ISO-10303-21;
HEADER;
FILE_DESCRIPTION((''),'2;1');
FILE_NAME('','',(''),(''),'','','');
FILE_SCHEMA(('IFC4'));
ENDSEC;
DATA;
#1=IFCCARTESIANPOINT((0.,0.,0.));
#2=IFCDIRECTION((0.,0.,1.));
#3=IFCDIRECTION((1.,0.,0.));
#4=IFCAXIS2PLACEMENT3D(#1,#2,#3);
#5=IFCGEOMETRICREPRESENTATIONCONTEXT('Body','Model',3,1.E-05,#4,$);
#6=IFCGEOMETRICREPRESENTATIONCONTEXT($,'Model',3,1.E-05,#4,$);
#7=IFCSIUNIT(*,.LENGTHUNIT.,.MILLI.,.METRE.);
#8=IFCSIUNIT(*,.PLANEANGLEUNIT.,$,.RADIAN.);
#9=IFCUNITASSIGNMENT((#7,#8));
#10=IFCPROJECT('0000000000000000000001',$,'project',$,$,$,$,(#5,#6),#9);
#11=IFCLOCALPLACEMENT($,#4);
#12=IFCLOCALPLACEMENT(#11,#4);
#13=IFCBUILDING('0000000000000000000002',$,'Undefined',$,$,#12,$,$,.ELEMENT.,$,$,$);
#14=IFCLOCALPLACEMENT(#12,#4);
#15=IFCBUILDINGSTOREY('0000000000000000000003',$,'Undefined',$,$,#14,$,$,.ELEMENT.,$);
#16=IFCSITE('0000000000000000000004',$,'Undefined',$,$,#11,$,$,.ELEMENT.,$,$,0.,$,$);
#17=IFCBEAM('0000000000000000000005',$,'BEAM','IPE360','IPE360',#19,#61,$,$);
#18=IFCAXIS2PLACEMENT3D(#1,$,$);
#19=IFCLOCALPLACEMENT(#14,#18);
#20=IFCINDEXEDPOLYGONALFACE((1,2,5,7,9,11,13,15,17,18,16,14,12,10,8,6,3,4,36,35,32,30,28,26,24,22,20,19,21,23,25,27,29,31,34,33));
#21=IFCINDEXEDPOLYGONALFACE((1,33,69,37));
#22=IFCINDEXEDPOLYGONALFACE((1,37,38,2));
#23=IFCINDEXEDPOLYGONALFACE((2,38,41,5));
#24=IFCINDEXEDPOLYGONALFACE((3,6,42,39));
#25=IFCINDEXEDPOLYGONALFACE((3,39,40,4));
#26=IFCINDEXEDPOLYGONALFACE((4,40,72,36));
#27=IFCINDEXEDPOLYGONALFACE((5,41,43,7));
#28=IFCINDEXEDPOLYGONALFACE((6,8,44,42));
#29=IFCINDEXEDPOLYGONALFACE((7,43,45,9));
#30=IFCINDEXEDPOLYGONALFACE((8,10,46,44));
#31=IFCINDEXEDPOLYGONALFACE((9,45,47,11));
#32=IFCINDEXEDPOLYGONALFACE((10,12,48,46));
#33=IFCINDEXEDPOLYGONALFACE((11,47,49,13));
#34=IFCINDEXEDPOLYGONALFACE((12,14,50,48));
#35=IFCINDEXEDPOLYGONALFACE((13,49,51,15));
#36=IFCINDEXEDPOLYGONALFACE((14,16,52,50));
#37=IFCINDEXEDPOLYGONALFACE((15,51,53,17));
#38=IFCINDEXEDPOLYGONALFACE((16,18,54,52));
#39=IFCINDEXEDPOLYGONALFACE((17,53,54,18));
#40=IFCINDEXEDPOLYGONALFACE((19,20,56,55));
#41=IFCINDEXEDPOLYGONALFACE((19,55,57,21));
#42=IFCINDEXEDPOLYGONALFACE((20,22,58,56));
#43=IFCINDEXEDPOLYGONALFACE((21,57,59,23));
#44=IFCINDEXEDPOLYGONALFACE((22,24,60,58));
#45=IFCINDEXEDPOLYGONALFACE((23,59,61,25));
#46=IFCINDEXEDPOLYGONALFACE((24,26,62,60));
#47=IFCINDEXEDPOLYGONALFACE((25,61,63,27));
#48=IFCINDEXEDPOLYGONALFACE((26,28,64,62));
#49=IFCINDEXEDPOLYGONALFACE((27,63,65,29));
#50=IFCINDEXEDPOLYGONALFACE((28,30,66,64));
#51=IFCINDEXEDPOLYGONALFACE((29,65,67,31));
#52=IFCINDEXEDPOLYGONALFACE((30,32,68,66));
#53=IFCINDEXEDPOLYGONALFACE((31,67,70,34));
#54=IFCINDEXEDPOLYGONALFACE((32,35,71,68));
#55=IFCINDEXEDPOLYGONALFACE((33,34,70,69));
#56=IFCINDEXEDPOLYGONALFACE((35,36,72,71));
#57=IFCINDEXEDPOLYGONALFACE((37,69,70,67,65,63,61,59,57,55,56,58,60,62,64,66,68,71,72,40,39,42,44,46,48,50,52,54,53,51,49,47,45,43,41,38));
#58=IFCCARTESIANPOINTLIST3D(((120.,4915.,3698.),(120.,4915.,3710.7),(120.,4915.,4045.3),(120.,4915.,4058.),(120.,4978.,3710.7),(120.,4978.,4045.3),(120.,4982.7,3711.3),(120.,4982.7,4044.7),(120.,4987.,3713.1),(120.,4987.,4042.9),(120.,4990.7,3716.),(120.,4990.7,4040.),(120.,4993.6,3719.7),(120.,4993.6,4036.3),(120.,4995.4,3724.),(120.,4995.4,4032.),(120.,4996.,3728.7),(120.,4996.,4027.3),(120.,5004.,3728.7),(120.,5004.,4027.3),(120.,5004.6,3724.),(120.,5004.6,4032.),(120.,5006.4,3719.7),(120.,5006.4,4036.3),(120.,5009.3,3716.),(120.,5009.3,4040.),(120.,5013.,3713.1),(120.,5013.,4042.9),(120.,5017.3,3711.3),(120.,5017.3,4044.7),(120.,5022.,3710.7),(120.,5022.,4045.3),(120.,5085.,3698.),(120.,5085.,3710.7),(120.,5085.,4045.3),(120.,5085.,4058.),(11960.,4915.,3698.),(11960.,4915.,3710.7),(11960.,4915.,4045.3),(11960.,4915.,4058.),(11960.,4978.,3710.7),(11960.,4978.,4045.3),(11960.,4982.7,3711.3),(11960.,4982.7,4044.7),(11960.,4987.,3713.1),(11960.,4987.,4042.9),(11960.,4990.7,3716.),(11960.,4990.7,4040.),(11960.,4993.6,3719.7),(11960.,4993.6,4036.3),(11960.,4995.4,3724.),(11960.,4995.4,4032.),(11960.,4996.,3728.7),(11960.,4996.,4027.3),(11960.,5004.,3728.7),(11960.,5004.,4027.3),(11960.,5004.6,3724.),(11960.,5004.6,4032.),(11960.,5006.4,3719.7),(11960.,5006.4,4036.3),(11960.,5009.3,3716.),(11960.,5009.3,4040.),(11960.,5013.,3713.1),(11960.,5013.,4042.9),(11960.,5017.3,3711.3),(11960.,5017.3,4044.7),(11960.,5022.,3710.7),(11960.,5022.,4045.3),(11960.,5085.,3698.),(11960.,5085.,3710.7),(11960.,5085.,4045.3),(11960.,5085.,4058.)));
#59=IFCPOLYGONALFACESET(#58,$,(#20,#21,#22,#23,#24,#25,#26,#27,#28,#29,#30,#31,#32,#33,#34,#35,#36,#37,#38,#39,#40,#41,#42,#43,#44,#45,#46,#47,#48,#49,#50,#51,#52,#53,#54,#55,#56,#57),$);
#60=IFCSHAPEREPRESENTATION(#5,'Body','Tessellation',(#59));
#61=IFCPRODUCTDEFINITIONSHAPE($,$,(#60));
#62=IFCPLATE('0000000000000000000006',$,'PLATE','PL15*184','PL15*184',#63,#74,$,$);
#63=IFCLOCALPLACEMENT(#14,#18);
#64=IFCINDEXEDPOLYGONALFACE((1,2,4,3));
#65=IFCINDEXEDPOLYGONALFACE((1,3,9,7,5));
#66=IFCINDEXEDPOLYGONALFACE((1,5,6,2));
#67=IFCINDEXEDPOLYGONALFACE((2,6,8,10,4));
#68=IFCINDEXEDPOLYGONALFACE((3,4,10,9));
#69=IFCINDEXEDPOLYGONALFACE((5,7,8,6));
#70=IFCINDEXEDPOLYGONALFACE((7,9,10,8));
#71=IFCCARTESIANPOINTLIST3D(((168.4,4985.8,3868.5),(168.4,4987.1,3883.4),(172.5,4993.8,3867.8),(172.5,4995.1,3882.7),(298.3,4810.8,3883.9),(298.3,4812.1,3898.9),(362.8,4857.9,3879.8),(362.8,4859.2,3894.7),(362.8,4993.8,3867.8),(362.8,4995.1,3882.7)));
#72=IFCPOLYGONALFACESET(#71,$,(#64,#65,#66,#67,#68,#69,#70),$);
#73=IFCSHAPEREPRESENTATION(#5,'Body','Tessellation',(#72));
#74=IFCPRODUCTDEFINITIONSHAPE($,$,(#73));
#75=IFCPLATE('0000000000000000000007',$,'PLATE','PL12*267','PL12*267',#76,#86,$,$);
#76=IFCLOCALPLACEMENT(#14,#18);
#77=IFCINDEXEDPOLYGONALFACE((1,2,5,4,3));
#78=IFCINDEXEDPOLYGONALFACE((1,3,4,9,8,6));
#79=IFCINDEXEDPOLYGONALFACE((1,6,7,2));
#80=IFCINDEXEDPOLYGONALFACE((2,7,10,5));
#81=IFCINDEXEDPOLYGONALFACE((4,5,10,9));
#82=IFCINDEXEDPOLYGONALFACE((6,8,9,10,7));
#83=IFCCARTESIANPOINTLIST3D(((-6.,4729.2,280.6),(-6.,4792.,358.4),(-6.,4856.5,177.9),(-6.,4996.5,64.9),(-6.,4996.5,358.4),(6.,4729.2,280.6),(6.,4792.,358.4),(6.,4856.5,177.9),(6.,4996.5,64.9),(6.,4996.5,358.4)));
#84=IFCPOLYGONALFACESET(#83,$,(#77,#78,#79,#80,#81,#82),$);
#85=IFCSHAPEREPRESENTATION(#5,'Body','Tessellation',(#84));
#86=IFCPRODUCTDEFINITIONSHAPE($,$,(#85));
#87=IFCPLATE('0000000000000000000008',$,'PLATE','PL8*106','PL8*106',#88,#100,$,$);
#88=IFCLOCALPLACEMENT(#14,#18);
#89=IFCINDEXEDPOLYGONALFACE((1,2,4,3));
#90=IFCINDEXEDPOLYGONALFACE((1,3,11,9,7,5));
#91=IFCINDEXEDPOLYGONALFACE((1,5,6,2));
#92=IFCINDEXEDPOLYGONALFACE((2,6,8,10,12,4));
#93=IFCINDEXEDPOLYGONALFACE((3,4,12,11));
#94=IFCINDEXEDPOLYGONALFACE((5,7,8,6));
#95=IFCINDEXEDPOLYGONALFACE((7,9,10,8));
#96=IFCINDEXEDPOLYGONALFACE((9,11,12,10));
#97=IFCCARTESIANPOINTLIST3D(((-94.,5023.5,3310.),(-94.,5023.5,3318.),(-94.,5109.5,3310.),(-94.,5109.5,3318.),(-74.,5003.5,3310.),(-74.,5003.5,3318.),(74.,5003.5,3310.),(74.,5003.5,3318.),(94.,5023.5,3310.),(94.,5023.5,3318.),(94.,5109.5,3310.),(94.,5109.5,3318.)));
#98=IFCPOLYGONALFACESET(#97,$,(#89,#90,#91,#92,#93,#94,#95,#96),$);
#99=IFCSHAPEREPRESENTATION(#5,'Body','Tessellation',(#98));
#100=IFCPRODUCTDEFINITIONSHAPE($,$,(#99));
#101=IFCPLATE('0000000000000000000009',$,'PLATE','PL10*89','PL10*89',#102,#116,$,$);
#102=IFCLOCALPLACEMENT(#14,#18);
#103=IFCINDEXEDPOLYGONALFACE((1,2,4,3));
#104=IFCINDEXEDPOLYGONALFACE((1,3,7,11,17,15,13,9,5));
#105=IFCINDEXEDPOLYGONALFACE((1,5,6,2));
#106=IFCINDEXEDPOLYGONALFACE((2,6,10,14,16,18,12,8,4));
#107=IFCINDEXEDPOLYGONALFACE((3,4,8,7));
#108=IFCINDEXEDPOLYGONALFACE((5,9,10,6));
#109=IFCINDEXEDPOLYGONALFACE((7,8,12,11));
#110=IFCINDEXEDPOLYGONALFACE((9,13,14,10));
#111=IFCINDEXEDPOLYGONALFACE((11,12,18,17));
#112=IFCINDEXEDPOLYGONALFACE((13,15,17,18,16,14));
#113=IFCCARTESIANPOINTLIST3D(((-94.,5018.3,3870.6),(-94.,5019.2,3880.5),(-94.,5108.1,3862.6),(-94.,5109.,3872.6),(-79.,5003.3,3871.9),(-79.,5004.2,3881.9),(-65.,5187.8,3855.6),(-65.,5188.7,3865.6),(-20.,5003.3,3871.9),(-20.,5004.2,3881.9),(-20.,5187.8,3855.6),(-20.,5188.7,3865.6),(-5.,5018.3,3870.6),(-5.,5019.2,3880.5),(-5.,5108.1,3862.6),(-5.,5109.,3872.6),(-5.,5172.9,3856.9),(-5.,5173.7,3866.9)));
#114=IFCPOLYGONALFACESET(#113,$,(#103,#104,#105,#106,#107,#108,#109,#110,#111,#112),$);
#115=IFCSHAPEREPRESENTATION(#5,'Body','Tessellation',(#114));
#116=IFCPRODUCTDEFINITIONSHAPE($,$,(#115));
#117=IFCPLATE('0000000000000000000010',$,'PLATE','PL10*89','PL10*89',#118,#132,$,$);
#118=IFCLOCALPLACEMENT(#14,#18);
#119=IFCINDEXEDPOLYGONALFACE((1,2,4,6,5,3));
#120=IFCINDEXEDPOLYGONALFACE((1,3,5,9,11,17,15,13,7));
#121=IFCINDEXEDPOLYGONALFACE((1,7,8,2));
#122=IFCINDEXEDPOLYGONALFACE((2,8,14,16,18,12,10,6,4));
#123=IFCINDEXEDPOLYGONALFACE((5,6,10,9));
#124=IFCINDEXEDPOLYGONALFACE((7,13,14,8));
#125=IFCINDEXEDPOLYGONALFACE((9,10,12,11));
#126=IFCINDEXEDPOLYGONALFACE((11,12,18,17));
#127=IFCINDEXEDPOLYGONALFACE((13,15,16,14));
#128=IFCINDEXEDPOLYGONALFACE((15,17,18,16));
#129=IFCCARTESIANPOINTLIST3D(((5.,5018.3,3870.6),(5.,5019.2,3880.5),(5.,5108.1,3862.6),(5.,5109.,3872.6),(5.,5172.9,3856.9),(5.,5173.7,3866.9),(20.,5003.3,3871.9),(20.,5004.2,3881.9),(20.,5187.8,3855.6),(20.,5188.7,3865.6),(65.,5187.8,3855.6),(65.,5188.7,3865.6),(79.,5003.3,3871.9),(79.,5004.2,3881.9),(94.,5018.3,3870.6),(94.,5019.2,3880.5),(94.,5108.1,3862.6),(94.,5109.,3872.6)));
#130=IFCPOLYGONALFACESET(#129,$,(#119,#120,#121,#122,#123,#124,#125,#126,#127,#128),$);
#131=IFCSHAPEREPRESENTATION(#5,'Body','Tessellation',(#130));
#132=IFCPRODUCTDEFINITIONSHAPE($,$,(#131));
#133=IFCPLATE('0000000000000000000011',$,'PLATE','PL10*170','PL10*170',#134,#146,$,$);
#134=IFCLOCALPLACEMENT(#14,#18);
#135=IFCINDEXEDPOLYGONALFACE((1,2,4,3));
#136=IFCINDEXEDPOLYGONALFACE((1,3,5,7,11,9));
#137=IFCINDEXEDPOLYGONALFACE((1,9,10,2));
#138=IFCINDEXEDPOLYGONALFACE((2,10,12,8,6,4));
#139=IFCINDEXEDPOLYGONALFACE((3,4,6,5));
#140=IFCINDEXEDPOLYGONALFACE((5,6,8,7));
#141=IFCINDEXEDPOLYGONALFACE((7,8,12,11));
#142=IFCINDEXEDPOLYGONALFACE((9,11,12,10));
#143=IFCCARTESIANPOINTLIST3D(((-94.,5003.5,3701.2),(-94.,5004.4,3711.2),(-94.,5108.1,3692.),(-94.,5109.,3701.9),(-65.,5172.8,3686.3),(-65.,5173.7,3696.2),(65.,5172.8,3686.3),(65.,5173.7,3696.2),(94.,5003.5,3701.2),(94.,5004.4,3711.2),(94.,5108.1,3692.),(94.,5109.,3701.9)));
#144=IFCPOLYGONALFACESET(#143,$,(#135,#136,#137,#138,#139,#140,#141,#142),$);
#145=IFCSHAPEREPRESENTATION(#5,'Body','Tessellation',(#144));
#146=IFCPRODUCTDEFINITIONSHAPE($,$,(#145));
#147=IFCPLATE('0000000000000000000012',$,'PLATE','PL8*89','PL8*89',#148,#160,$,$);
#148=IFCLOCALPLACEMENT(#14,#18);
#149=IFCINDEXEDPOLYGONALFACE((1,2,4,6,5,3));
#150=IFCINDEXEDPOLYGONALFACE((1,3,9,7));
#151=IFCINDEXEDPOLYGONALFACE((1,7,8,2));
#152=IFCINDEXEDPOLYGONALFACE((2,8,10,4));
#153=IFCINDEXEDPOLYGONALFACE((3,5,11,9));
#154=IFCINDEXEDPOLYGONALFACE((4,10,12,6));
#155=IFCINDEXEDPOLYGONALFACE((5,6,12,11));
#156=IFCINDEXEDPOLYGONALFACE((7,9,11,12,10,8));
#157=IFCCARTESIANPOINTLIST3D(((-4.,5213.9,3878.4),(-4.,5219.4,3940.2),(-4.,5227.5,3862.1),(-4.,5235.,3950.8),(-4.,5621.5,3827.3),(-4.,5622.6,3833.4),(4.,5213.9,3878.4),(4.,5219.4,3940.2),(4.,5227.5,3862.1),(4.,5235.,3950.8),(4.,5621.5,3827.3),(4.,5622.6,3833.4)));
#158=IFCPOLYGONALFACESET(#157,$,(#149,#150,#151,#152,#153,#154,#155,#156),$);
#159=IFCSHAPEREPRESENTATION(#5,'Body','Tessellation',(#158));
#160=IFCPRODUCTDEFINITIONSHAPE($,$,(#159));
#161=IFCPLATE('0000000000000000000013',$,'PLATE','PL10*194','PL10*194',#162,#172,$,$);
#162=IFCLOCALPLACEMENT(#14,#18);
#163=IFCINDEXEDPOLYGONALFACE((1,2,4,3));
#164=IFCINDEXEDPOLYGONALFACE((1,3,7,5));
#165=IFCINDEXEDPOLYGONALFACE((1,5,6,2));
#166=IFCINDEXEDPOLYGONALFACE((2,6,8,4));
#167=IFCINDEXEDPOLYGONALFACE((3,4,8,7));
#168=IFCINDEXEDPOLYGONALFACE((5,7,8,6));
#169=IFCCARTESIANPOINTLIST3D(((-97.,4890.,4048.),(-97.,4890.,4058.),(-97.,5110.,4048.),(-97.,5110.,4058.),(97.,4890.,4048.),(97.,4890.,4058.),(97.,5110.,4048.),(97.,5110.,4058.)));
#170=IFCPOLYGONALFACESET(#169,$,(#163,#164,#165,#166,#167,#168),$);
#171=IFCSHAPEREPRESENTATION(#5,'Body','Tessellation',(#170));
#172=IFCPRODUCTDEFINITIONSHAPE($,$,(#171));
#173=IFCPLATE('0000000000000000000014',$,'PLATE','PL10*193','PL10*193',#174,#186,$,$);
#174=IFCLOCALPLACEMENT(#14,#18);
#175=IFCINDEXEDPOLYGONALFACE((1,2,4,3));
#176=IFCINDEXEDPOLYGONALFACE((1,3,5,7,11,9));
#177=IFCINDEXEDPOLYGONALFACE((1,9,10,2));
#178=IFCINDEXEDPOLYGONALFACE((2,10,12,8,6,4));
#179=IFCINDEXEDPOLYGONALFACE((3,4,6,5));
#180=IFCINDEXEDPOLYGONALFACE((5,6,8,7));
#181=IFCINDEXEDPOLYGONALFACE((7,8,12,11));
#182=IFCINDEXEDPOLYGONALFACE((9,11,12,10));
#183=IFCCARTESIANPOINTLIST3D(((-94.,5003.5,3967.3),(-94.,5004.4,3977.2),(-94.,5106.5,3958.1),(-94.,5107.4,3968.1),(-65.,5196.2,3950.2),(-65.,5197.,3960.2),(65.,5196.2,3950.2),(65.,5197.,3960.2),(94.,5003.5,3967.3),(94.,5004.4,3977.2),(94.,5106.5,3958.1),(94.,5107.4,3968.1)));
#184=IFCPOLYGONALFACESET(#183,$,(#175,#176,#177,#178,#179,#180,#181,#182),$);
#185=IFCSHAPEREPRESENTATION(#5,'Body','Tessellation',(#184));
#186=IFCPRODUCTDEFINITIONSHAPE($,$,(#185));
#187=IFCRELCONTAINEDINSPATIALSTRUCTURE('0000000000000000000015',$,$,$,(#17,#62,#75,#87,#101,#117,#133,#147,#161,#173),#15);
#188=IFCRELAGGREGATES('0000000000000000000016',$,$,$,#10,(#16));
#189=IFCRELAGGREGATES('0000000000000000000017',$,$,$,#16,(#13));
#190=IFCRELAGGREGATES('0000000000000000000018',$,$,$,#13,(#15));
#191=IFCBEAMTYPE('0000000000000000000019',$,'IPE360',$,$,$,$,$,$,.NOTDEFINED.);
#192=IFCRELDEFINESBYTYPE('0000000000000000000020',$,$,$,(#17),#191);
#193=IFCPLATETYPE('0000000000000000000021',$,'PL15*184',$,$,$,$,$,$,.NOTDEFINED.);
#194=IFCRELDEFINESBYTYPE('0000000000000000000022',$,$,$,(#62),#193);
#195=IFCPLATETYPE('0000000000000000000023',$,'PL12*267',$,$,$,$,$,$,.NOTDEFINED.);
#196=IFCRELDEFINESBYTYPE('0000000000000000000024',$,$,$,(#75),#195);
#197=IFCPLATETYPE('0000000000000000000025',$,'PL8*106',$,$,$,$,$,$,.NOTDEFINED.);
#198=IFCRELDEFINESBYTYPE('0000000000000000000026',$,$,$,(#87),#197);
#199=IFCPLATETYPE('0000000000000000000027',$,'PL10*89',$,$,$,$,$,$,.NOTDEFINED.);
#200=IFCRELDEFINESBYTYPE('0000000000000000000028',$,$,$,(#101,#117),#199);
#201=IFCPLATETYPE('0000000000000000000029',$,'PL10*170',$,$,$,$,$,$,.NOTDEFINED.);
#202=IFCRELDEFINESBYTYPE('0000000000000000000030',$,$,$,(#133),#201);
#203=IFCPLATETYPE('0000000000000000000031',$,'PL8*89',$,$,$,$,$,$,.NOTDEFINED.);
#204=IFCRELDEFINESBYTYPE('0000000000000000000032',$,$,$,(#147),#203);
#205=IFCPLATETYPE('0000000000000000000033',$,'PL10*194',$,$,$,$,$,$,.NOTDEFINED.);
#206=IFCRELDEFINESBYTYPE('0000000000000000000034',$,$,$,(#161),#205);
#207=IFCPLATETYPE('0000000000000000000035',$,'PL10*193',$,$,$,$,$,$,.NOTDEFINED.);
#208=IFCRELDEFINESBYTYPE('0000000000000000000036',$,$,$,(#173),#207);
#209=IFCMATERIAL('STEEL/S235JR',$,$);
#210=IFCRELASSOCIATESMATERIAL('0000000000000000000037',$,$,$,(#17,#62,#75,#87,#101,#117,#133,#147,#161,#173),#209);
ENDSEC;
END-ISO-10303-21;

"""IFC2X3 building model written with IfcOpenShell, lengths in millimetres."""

from ifc_helpers import new_model, si_unit, frame, origin_with_axes, origin_2d_with_axis, place, context, project, spatial, polyline, i_section, outline, extrude, material, type_object, element, save


model = new_model("IFC2X3")

# Units and contexts
model_context_1 = context("Model", 3, precision=1e-05, world=origin_with_axes(), identifier="Body")
model_context_2 = context("Model", 3, precision=1e-05, world=origin_with_axes())
ifc_project = project(units=[si_unit("LENGTHUNIT", "METRE", prefix="MILLI"), si_unit("PLANEANGLEUNIT", "RADIAN")], contexts=[model_context_1, model_context_2])

# Site, building, storey
site_placement = place(None, origin_with_axes())
site = spatial("IfcSite", under=ifc_project, at=site_placement, Name="Undefined", CompositionType="ELEMENT", RefElevation=0.0)
building_placement = place(site_placement, origin_with_axes())
building = spatial("IfcBuilding", under=site, at=building_placement, Name="Undefined", CompositionType="ELEMENT")
storey_placement = place(building_placement, origin_with_axes())
storey = spatial("IfcBuildingStorey", under=building, at=storey_placement, Name="Undefined", CompositionType="ELEMENT")

# Shared definitions
ifc_material = material(Name="STEEL/S235JR")

# Beam
beam_type_1 = type_object("IfcBeamType", Name="IPE360", PredefinedType="NOTDEFINED")
beam_1_placement = place(storey_placement, frame((40.0, 5000.0, 3878.0), z_axis=(0.0, 0.0, 1.0), x_axis=(1.0, 0.0, 0.0)))
element("IfcBeam", 1, at=beam_1_placement, inside=storey, type_object=beam_type_1, material=ifc_material, Name="BEAM", Description="IPE360", ObjectType="IPE360", context=model_context_1, shape_type="SweptSolid", body=[
    extrude(i_section(OverallWidth=170.0, OverallDepth=360.0, WebThickness=8.0, FlangeThickness=12.7, FilletRadius=18.0, at=origin_2d_with_axis()), frame((11920.0, 0.0, 0.0), z_axis=(-1.0, 0.0, 0.0), x_axis=(0.0, -1.0, 0.0)), (0.0, 0.0, 1.0), 11840.0),
])

# Plates
plate_type_1 = type_object("IfcPlateType", Name="PL15*184", PredefinedType="NOTDEFINED")
plate_1_placement = place(storey_placement, frame((362.8, 4994.4, 3875.3), z_axis=(0.0, 0.087999, 0.996121), x_axis=(-1.0, 0.0, 0.0)))
element("IfcPlate", 2, at=plate_1_placement, inside=storey, type_object=plate_type_1, material=ifc_material, Name="PLATE", Description="PL15*184", ObjectType="PL15*184", context=model_context_1, shape_type="SweptSolid", body=[
    extrude(outline(polyline([(0.0, 0.0), (190.3, 0.0), (194.4, 8.0), (64.5, 183.7), (0.0, 136.4), (0.0, 0.0)])), frame((0.0, 0.0, -7.5), z_axis=(0.0, 0.0, 1.0), x_axis=(1.0, 0.0, 0.0)), (0.0, 0.0, 1.0), 15.0),
])
plate_type_2 = type_object("IfcPlateType", Name="PL12*267", PredefinedType="NOTDEFINED")
plate_2_placement = place(storey_placement, frame((0.0, 4996.5, 64.9), z_axis=(1.0, 0.0, 0.0), x_axis=(0.0, -0.000016, 1.0)))
element("IfcPlate", 3, at=plate_2_placement, inside=storey, type_object=plate_type_2, material=ifc_material, Name="PLATE", Description="PL12*267", ObjectType="PL12*267", context=model_context_1, shape_type="SweptSolid", body=[
    extrude(outline(polyline([(0.0, 0.0), (293.5, 0.0), (293.5, 204.5), (215.7, 267.3), (112.9, 140.0), (0.0, 0.0)])), frame((0.0, 0.0, -6.0), z_axis=(0.0, 0.0, 1.0), x_axis=(1.0, 0.0, 0.0)), (0.0, 0.0, 1.0), 12.0),
])
plate_type_3 = type_object("IfcPlateType", Name="PL8*106", PredefinedType="NOTDEFINED")
plate_3_placement = place(storey_placement, frame((94.0, 5109.5, 3314.0), z_axis=(0.0, 0.0, -1.0), x_axis=(0.0, -1.0, 0.0)))
element("IfcPlate", 4, at=plate_3_placement, inside=storey, type_object=plate_type_3, material=ifc_material, Name="PLATE", Description="PL8*106", ObjectType="PL8*106", context=model_context_1, shape_type="SweptSolid", body=[
    extrude(outline(polyline([(0.0, 0.0), (86.0, 0.0), (106.0, 20.0), (106.0, 168.0), (86.0, 188.0), (0.0, 188.0), (0.0, 0.0)])), frame((0.0, 0.0, -4.0), z_axis=(0.0, 0.0, 1.0), x_axis=(1.0, 0.0, 0.0)), (0.0, 0.0, 1.0), 8.0),
])
plate_type_4 = type_object("IfcPlateType", Name="PL10*89", PredefinedType="NOTDEFINED")
for number, where, z_axis, x_axis, name in (
    (5, (-5.0, 5188.2, 3860.6), (0.0, -0.08801, -0.99612), (0.0, -0.99612, 0.08801), "PLATE"),
    (6, (5.0, 5188.2, 3860.6), (0.0, 0.08801, 0.99612), (0.0, -0.99612, 0.08801), "PLATE"),
):
    element("IfcPlate", number, at=place(storey_placement, frame(where, z_axis=z_axis, x_axis=x_axis)), inside=storey, type_object=plate_type_4, material=ifc_material, Name=name, Description="PL10*89", ObjectType="PL10*89", context=model_context_1, shape_type="SweptSolid", body=[
        extrude(outline(polyline([(0.0, 15.0), (15.0, 0.0), (80.0, 0.0), (170.2, 0.0), (185.2, 15.0), (185.2, 74.0), (170.2, 89.0), (80.0, 89.0), (0.0, 60.0), (0.0, 15.0)])), frame((0.0, 0.0, -5.0), z_axis=(0.0, 0.0, 1.0), x_axis=(1.0, 0.0, 0.0)), (0.0, 0.0, 1.0), 10.0),
    ])
plate_type_5 = type_object("IfcPlateType", Name="PL10*170", PredefinedType="NOTDEFINED")
plate_4_placement = place(storey_placement, frame((-65.0, 5173.3, 3691.2), z_axis=(0.0, 0.08801, 0.99612), x_axis=(-0.407441, -0.909688, 0.080373)))
element("IfcPlate", 7, at=plate_4_placement, inside=storey, type_object=plate_type_5, material=ifc_material, Name="PLATE", Description="PL10*170", ObjectType="PL10*170", context=model_context_1, shape_type="SweptSolid", body=[
    extrude(outline(polyline([(0.0, 0.0), (71.2, 0.0), (167.1, 42.8), (90.5, 214.5), (-5.4, 171.7), (-53.0, 118.7), (0.0, 0.0)])), frame((0.0, 0.0, -5.0), z_axis=(0.0, 0.0, 1.0), x_axis=(1.0, 0.0, 0.0)), (0.0, 0.0, 1.0), 10.0),
])
plate_type_6 = type_object("IfcPlateType", Name="PL8*89", PredefinedType="NOTDEFINED")
plate_5_placement = place(storey_placement, frame((0.0, 5212.6, 3863.4), z_axis=(-1.0, 0.0, 0.0), x_axis=(0.0, 0.08801, 0.99612)))
element("IfcPlate", 8, at=plate_5_placement, inside=storey, type_object=plate_type_6, material=ifc_material, Name="PLATE", Description="PL8*89", ObjectType="PL8*89", context=model_context_1, shape_type="SweptSolid", body=[
    extrude(outline(polyline([(0.0, 15.0), (15.0, 0.0), (77.1, 0.0), (89.0, 14.7), (6.1, 411.1), (0.0, 410.5), (0.0, 15.0)])), frame((0.0, 0.0, -4.0), z_axis=(0.0, 0.0, 1.0), x_axis=(1.0, 0.0, 0.0)), (0.0, 0.0, 1.0), 8.0),
])
plate_type_7 = type_object("IfcPlateType", Name="PL10*194", PredefinedType="NOTDEFINED")
plate_6_placement = place(storey_placement, frame((97.0, 5110.0, 4053.0), z_axis=(0.0, 0.0, 1.0), x_axis=(-1.0, 0.0, 0.0)))
element("IfcPlate", 9, at=plate_6_placement, inside=storey, type_object=plate_type_7, material=ifc_material, Name="PLATE", Description="PL10*194", ObjectType="PL10*194", context=model_context_1, shape_type="SweptSolid", body=[
    extrude(outline(polyline([(0.0, 0.0), (194.0, 0.0), (194.0, 220.0), (0.0, 220.0), (0.0, 0.0)])), frame((0.0, 0.0, -5.0), z_axis=(0.0, 0.0, 1.0), x_axis=(1.0, 0.0, 0.0)), (0.0, 0.0, 1.0), 10.0),
])
plate_type_8 = type_object("IfcPlateType", Name="PL10*193", PredefinedType="NOTDEFINED")
plate_7_placement = place(storey_placement, frame((-65.0, 5196.6, 3955.2), z_axis=(0.0, 0.08801, 0.99612), x_axis=(-0.306693, -0.948115, 0.083768)))
element("IfcPlate", 10, at=plate_7_placement, inside=storey, type_object=plate_type_8, material=ifc_material, Name="PLATE", Description="PL10*193", ObjectType="PL10*193", context=model_context_1, shape_type="SweptSolid", body=[
    extrude(outline(polyline([(0.0, 0.0), (94.6, 0.0), (193.0, 31.7), (135.3, 210.7), (36.9, 178.9), (-39.9, 123.7), (0.0, 0.0)])), frame((0.0, 0.0, -5.0), z_axis=(0.0, 0.0, 1.0), x_axis=(1.0, 0.0, 0.0)), (0.0, 0.0, 1.0), 10.0),
])

save(model, "model.ifc")
